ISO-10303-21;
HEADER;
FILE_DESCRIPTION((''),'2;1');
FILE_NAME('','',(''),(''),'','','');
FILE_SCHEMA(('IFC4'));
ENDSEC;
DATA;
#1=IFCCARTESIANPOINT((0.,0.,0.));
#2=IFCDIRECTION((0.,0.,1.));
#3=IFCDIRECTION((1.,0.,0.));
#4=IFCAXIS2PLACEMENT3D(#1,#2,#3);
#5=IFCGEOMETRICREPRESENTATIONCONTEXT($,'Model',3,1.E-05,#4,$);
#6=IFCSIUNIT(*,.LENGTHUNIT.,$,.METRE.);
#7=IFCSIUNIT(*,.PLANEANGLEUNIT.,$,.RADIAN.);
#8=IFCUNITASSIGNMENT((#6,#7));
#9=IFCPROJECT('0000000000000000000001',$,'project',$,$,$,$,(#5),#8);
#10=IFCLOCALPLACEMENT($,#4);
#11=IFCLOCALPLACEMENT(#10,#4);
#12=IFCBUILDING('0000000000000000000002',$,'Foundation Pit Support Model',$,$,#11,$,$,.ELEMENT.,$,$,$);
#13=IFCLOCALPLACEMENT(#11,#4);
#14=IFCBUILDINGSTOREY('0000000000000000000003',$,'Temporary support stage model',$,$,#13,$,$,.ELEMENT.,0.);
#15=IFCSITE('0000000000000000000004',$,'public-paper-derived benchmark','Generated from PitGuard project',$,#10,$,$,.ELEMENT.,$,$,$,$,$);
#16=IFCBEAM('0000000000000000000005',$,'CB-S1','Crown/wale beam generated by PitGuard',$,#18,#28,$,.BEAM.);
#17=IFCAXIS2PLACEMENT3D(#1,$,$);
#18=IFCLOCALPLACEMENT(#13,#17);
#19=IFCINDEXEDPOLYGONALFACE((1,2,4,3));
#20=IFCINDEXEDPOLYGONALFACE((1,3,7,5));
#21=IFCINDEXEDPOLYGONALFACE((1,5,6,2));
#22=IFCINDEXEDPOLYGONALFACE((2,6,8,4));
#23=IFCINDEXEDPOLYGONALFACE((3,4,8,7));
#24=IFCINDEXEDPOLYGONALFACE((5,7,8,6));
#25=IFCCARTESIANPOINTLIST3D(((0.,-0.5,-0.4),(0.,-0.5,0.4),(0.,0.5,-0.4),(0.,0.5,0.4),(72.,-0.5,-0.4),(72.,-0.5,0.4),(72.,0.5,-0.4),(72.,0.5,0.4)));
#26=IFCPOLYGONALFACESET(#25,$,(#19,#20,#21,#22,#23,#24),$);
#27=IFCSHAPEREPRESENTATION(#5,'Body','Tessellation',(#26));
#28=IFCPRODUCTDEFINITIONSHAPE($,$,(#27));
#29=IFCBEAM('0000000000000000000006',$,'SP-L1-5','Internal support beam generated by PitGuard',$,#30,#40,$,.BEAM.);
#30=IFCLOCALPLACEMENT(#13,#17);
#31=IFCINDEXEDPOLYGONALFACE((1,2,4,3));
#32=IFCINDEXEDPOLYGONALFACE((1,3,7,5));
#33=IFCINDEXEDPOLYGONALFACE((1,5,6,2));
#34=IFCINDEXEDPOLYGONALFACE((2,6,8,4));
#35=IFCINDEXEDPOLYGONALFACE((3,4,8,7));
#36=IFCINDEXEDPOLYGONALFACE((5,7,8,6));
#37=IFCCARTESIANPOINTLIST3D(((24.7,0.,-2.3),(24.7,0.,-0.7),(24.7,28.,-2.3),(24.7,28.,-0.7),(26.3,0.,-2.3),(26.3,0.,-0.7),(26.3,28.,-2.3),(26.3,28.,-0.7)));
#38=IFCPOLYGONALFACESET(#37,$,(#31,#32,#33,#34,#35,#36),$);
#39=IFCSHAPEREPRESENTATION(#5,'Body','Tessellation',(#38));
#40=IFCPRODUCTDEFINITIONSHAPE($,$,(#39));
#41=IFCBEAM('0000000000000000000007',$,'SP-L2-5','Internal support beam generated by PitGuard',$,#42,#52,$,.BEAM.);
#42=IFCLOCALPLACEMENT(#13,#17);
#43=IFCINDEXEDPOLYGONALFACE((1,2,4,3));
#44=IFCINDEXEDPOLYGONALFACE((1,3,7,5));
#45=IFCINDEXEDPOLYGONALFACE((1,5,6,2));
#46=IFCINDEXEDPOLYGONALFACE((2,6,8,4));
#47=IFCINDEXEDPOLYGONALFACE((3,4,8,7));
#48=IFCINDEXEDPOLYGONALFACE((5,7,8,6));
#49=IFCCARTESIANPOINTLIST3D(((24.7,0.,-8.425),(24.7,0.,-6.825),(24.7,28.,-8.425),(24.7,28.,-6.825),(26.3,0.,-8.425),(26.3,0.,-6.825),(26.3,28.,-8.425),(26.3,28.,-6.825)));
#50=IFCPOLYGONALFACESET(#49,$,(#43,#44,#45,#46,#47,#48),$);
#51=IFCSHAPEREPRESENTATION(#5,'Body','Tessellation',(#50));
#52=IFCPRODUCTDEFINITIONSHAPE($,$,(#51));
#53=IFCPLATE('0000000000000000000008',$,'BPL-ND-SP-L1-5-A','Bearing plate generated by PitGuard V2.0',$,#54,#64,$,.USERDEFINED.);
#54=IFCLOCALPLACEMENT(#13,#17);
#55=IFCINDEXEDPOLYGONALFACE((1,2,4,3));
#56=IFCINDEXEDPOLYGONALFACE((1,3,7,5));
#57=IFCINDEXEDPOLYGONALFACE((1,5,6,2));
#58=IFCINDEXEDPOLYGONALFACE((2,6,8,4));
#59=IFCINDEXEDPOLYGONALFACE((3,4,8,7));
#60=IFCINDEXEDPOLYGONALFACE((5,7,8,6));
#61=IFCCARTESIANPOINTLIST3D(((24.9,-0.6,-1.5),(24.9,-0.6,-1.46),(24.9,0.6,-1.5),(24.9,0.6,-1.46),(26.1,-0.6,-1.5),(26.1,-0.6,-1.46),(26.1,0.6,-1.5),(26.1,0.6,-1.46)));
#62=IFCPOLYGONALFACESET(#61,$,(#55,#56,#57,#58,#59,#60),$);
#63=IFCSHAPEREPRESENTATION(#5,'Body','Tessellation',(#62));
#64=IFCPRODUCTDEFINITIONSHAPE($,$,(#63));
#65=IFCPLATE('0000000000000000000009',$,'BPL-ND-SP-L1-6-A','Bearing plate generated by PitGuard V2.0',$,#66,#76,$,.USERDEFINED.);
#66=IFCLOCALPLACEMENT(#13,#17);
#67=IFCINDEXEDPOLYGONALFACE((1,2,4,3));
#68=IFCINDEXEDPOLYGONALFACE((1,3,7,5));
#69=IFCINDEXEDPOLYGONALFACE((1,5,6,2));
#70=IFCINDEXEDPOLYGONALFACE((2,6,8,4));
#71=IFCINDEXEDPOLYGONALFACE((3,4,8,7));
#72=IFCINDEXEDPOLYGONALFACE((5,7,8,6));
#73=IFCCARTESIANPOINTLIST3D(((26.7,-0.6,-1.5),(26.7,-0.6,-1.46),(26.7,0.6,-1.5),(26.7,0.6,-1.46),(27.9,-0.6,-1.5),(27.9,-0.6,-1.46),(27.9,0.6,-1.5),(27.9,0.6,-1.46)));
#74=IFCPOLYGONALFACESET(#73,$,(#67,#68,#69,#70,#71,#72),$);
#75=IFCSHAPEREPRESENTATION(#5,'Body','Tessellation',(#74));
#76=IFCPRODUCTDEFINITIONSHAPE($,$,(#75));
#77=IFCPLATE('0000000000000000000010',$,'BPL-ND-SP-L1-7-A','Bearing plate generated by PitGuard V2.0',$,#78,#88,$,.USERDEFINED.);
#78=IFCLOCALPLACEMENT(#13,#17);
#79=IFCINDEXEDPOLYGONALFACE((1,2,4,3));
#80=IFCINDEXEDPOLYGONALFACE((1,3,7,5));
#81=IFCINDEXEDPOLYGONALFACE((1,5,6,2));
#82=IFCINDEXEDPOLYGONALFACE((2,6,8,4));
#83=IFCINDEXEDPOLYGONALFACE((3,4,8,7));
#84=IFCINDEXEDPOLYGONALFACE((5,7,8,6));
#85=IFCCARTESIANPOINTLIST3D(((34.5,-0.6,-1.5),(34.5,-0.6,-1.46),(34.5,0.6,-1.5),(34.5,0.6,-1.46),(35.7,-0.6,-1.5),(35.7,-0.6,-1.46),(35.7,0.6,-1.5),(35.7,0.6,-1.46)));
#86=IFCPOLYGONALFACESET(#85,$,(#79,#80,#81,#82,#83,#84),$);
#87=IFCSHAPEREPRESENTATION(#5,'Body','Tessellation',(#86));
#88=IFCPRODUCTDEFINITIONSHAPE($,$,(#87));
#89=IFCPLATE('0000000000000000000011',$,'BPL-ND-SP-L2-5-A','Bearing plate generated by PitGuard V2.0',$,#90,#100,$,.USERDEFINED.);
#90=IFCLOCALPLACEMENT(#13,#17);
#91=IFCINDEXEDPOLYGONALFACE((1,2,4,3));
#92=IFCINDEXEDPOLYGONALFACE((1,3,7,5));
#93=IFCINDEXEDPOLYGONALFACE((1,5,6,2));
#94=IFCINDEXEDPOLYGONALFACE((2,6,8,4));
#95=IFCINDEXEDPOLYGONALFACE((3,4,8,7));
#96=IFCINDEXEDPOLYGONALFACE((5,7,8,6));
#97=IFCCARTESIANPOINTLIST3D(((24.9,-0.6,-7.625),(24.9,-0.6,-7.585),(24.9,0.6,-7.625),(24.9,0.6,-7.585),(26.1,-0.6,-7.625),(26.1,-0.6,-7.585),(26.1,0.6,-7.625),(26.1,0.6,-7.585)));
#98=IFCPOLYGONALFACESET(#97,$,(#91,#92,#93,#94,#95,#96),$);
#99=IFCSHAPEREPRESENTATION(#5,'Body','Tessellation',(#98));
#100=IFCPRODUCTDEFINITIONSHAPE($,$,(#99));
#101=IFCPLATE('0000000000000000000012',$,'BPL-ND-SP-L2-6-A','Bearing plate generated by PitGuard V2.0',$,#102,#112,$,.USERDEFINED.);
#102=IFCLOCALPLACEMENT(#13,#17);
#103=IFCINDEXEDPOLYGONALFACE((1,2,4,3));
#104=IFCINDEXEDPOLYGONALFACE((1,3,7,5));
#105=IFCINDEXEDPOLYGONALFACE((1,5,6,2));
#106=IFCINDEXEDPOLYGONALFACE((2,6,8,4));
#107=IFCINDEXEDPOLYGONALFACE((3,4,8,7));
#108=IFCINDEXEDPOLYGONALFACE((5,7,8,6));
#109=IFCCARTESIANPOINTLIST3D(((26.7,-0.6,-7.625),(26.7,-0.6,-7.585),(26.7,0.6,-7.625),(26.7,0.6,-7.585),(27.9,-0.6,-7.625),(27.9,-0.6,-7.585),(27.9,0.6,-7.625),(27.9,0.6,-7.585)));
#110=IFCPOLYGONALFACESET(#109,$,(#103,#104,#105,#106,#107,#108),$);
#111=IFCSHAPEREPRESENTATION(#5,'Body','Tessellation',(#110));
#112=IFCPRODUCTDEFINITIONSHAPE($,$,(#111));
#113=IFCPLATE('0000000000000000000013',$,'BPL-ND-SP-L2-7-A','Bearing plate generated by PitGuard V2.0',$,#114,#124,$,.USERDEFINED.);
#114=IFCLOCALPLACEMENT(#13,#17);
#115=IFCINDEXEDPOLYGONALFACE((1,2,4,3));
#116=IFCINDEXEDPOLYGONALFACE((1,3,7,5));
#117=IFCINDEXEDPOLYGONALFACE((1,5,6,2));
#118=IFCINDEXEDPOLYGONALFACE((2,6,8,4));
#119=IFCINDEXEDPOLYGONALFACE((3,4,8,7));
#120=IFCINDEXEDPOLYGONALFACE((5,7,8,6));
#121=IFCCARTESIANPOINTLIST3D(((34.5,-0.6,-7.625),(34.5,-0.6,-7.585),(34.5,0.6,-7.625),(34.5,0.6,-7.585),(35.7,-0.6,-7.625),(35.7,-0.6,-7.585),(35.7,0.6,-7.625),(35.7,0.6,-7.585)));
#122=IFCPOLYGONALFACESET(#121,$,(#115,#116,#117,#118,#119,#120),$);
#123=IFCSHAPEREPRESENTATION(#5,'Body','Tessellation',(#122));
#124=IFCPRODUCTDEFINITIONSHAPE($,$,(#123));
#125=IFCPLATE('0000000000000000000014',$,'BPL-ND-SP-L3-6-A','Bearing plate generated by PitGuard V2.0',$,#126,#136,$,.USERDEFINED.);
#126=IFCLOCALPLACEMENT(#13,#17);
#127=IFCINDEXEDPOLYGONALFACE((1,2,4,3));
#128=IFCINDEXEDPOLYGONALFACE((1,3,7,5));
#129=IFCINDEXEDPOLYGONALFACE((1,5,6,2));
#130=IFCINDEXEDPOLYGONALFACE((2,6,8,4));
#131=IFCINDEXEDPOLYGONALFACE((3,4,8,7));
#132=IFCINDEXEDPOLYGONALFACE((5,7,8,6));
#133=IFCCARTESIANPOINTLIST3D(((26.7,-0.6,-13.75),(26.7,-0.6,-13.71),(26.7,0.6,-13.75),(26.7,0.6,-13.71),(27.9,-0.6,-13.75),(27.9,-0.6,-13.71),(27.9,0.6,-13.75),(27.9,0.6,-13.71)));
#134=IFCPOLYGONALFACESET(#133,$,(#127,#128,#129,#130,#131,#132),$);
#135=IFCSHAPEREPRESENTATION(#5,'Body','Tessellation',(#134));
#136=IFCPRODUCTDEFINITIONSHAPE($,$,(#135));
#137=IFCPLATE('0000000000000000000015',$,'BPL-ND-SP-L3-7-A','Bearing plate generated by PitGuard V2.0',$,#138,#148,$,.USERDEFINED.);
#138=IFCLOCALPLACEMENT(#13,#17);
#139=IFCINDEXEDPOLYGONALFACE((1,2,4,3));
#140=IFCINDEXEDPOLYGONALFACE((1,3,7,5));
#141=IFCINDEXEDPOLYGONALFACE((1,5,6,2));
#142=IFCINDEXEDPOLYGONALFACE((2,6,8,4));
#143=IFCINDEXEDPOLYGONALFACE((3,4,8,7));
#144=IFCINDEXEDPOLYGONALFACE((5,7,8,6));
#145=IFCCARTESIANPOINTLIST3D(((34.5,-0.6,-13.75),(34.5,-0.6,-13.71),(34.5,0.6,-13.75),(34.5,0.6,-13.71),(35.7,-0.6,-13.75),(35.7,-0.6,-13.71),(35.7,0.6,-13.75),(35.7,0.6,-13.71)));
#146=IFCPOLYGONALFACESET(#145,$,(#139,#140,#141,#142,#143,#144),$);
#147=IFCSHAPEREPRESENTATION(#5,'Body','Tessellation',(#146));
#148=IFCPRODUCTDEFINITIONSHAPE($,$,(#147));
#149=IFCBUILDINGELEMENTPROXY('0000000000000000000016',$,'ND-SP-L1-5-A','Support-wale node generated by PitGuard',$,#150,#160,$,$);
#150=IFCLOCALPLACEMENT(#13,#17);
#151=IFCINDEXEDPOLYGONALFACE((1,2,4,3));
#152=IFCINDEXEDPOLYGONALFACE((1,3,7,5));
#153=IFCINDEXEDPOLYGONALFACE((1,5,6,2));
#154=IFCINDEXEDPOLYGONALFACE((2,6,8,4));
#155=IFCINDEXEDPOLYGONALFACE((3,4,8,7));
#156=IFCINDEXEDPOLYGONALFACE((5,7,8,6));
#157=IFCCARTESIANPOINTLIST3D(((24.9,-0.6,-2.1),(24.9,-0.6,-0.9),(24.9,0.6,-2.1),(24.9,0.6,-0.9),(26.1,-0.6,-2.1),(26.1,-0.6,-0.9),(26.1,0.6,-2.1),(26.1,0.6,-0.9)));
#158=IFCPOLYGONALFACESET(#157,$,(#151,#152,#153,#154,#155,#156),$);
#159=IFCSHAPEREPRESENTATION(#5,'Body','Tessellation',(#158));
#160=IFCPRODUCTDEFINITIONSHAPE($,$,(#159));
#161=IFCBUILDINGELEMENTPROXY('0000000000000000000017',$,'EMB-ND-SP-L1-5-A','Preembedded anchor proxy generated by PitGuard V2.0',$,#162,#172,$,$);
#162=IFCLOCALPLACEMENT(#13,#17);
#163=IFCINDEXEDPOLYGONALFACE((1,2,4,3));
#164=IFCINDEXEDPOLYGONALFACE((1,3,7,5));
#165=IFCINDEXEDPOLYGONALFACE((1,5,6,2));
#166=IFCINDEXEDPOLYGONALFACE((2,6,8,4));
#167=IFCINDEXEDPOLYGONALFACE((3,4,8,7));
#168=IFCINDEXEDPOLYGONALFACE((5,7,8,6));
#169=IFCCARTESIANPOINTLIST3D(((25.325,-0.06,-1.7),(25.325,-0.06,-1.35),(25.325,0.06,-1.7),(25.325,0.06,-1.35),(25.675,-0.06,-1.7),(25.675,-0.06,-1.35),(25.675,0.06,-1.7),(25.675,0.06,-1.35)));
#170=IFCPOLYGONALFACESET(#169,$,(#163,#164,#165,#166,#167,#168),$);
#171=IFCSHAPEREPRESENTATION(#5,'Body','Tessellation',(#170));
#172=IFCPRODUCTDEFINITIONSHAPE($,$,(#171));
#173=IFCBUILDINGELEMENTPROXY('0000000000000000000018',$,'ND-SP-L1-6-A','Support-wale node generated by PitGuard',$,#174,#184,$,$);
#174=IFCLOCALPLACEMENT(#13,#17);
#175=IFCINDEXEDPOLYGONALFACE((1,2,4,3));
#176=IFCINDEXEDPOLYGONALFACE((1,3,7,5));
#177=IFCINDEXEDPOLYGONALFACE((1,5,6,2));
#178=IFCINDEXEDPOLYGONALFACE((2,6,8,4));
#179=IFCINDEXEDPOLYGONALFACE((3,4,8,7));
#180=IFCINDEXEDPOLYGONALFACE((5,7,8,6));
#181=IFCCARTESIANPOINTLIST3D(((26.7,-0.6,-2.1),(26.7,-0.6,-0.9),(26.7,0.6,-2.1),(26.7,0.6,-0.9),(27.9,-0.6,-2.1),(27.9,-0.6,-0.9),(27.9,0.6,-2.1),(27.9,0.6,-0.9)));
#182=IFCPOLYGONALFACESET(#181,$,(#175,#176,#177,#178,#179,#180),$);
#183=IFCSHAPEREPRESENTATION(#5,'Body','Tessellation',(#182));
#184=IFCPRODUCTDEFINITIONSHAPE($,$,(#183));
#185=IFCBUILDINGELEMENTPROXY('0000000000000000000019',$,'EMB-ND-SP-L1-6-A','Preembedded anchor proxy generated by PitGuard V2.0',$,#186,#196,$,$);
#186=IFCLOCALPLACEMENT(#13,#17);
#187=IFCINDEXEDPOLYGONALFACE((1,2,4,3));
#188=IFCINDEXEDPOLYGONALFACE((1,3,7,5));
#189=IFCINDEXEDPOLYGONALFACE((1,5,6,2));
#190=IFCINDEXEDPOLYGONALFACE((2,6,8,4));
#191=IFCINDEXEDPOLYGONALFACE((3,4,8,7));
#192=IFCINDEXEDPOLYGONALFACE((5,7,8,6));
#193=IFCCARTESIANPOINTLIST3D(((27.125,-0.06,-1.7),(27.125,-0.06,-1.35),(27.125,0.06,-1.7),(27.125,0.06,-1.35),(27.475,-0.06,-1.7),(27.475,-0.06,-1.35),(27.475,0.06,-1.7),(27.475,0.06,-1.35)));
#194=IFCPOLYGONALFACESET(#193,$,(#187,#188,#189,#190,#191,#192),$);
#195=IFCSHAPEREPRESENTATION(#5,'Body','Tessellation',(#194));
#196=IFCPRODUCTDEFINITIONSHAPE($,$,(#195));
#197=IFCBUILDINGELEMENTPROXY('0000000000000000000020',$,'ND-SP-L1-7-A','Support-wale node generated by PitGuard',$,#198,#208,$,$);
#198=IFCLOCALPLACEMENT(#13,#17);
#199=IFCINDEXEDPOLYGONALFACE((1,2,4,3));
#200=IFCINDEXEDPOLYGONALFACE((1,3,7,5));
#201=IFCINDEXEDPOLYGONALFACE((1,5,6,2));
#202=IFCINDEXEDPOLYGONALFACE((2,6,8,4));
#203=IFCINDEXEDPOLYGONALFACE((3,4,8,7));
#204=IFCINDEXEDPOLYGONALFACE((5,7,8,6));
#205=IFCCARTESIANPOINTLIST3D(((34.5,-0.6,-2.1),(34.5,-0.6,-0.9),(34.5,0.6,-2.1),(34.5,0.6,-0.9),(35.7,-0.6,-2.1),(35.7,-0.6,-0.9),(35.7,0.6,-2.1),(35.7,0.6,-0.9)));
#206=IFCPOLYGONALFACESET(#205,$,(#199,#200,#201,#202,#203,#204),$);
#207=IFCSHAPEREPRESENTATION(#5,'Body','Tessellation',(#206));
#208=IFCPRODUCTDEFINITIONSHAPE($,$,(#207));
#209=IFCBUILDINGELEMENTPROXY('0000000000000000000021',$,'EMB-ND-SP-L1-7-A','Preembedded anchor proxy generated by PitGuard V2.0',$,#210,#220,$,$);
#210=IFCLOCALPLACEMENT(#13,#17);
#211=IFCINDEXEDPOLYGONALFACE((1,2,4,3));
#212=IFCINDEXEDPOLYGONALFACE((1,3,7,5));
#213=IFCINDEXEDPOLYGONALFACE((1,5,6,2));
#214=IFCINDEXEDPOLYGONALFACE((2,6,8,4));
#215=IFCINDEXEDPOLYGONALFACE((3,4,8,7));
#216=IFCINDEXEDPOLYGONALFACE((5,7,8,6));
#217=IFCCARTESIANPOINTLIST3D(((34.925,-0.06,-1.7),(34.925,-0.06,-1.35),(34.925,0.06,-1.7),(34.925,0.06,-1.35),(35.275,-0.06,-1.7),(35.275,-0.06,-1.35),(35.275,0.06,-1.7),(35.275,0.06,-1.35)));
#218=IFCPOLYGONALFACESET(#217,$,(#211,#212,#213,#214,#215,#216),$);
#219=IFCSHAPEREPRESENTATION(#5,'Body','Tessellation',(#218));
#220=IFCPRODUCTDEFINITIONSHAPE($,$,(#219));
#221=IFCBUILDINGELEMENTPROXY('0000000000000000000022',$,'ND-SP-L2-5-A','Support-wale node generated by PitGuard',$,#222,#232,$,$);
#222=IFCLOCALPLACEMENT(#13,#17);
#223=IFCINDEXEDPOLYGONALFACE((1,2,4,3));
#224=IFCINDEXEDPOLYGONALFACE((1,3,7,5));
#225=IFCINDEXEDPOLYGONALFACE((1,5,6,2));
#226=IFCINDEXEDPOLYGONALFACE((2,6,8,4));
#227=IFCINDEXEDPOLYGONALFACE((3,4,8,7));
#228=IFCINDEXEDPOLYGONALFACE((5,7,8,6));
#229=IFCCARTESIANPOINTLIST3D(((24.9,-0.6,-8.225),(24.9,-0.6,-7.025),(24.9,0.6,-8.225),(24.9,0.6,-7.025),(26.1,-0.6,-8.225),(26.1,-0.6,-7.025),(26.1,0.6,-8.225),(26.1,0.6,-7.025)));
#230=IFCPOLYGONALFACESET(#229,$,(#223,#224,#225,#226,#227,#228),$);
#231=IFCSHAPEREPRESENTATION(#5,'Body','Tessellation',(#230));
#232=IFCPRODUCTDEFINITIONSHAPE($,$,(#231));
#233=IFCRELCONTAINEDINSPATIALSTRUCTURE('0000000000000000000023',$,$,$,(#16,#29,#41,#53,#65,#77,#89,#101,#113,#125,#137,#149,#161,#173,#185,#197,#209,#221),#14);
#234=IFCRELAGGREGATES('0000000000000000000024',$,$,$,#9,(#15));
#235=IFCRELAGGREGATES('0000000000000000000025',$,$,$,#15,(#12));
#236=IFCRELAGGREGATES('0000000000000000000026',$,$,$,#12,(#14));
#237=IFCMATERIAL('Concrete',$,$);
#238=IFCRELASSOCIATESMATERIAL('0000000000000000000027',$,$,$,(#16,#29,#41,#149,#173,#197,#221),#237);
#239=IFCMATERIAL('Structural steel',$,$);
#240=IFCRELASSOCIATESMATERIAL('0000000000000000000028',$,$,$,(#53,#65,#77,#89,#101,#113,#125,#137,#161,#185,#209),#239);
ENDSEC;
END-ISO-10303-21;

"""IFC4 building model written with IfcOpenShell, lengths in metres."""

from ifc_helpers import new_model, si_unit, frame, origin_with_axes, origin_2d, place, context, project, spatial, rectangle, extrude, material, element, save


model = new_model("IFC4")

# Units and contexts
model_context = context("Model", 3, precision=1e-05, world=origin_with_axes())
ifc_project = project(units=[si_unit("LENGTHUNIT", "METRE"), si_unit("PLANEANGLEUNIT", "RADIAN")], contexts=[model_context])

# Site, building, storey
site_placement = place(None, origin_with_axes())
site = spatial("IfcSite", under=ifc_project, at=site_placement, Name="public-paper-derived benchmark", Description="Generated from PitGuard project", CompositionType="ELEMENT")
building_placement = place(site_placement, origin_with_axes())
building = spatial("IfcBuilding", under=site, at=building_placement, Name="Foundation Pit Support Model", CompositionType="ELEMENT")
storey_placement = place(building_placement, origin_with_axes())
storey = spatial("IfcBuildingStorey", under=building, at=storey_placement, Name="Temporary support stage model", CompositionType="ELEMENT", Elevation=0.0)

# Beams
ifc_material_1 = material(Name="Concrete")
beam_placement = place(storey_placement, frame((36.0, 0.0, -0.4), z_axis=(0.0, 0.0, 1.0), x_axis=(1.0, 0.0, 0.0)))
element("IfcBeam", 1, at=beam_placement, inside=storey, material=ifc_material_1, Name="CB-S1", Description="Crown/wale beam generated by PitGuard", PredefinedType="BEAM", context=model_context, shape_type="SweptSolid", body=[
    extrude(rectangle(XDim=72.0, YDim=1.0, at=origin_2d()), origin_with_axes(), (0.0, 0.0, 1.0), 0.8),
])
for number, where, z_axis, x_axis, name in (
    (2, (25.5, 14.0, -2.3), (0.0, 0.0, 1.0), (0.0, 1.0, 0.0), "SP-L1-5"),
    (3, (25.5, 14.0, -8.425), (0.0, 0.0, 1.0), (0.0, 1.0, 0.0), "SP-L2-5"),
):
    element("IfcBeam", number, at=place(storey_placement, frame(where, z_axis=z_axis, x_axis=x_axis)), inside=storey, material=ifc_material_1, Name=name, Description="Internal support beam generated by PitGuard", PredefinedType="BEAM", context=model_context, shape_type="SweptSolid", body=[
        extrude(rectangle(XDim=28.0, YDim=1.6, at=origin_2d()), origin_with_axes(), (0.0, 0.0, 1.0), 1.6),
    ])

# Plates
ifc_material_2 = material(Name="Structural steel")
for number, where, z_axis, x_axis, name in (
    (4, (25.5, 0.0, -1.5), (0.0, 0.0, 1.0), (1.0, 0.0, 0.0), "BPL-ND-SP-L1-5-A"),
    (5, (27.3, 0.0, -1.5), (0.0, 0.0, 1.0), (1.0, 0.0, 0.0), "BPL-ND-SP-L1-6-A"),
    (6, (35.1, 0.0, -1.5), (0.0, 0.0, 1.0), (1.0, 0.0, 0.0), "BPL-ND-SP-L1-7-A"),
    (7, (25.5, 0.0, -7.625), (0.0, 0.0, 1.0), (1.0, 0.0, 0.0), "BPL-ND-SP-L2-5-A"),
    (8, (27.3, 0.0, -7.625), (0.0, 0.0, 1.0), (1.0, 0.0, 0.0), "BPL-ND-SP-L2-6-A"),
    (9, (35.1, 0.0, -7.625), (0.0, 0.0, 1.0), (1.0, 0.0, 0.0), "BPL-ND-SP-L2-7-A"),
    (10, (27.3, 0.0, -13.75), (0.0, 0.0, 1.0), (1.0, 0.0, 0.0), "BPL-ND-SP-L3-6-A"),
    (11, (35.1, 0.0, -13.75), (0.0, 0.0, 1.0), (1.0, 0.0, 0.0), "BPL-ND-SP-L3-7-A"),
):
    element("IfcPlate", number, at=place(storey_placement, frame(where, z_axis=z_axis, x_axis=x_axis)), inside=storey, material=ifc_material_2, Name=name, Description="Bearing plate generated by PitGuard V2.0", PredefinedType="USERDEFINED", context=model_context, shape_type="SweptSolid", body=[
        extrude(rectangle(XDim=1.2, YDim=1.2, at=origin_2d()), origin_with_axes(), (0.0, 0.0, 1.0), 0.04),
    ])

# Building element proxies
proxy_1_placement = place(storey_placement, frame((25.5, 0.0, -2.1), z_axis=(0.0, 0.0, 1.0), x_axis=(1.0, 0.0, 0.0)))
element("IfcBuildingElementProxy", 12, at=proxy_1_placement, inside=storey, material=ifc_material_1, Name="ND-SP-L1-5-A", Description="Support-wale node generated by PitGuard", context=model_context, shape_type="SweptSolid", body=[
    extrude(rectangle(XDim=1.2, YDim=1.2, at=origin_2d()), origin_with_axes(), (0.0, 0.0, 1.0), 1.2),
])
proxy_2_placement = place(storey_placement, frame((25.5, 0.0, -1.7), z_axis=(0.0, 0.0, 1.0), x_axis=(1.0, 0.0, 0.0)))
element("IfcBuildingElementProxy", 13, at=proxy_2_placement, inside=storey, material=ifc_material_2, Name="EMB-ND-SP-L1-5-A", Description="Preembedded anchor proxy generated by PitGuard V2.0", context=model_context, shape_type="SweptSolid", body=[
    extrude(rectangle(XDim=0.35, YDim=0.12, at=origin_2d()), origin_with_axes(), (0.0, 0.0, 1.0), 0.35),
])
proxy_3_placement = place(storey_placement, frame((27.3, 0.0, -2.1), z_axis=(0.0, 0.0, 1.0), x_axis=(1.0, 0.0, 0.0)))
element("IfcBuildingElementProxy", 14, at=proxy_3_placement, inside=storey, material=ifc_material_1, Name="ND-SP-L1-6-A", Description="Support-wale node generated by PitGuard", context=model_context, shape_type="SweptSolid", body=[
    extrude(rectangle(XDim=1.2, YDim=1.2, at=origin_2d()), origin_with_axes(), (0.0, 0.0, 1.0), 1.2),
])
proxy_4_placement = place(storey_placement, frame((27.3, 0.0, -1.7), z_axis=(0.0, 0.0, 1.0), x_axis=(1.0, 0.0, 0.0)))
element("IfcBuildingElementProxy", 15, at=proxy_4_placement, inside=storey, material=ifc_material_2, Name="EMB-ND-SP-L1-6-A", Description="Preembedded anchor proxy generated by PitGuard V2.0", context=model_context, shape_type="SweptSolid", body=[
    extrude(rectangle(XDim=0.35, YDim=0.12, at=origin_2d()), origin_with_axes(), (0.0, 0.0, 1.0), 0.35),
])
proxy_5_placement = place(storey_placement, frame((35.1, 0.0, -2.1), z_axis=(0.0, 0.0, 1.0), x_axis=(1.0, 0.0, 0.0)))
element("IfcBuildingElementProxy", 16, at=proxy_5_placement, inside=storey, material=ifc_material_1, Name="ND-SP-L1-7-A", Description="Support-wale node generated by PitGuard", context=model_context, shape_type="SweptSolid", body=[
    extrude(rectangle(XDim=1.2, YDim=1.2, at=origin_2d()), origin_with_axes(), (0.0, 0.0, 1.0), 1.2),
])
proxy_6_placement = place(storey_placement, frame((35.1, 0.0, -1.7), z_axis=(0.0, 0.0, 1.0), x_axis=(1.0, 0.0, 0.0)))
element("IfcBuildingElementProxy", 17, at=proxy_6_placement, inside=storey, material=ifc_material_2, Name="EMB-ND-SP-L1-7-A", Description="Preembedded anchor proxy generated by PitGuard V2.0", context=model_context, shape_type="SweptSolid", body=[
    extrude(rectangle(XDim=0.35, YDim=0.12, at=origin_2d()), origin_with_axes(), (0.0, 0.0, 1.0), 0.35),
])
proxy_7_placement = place(storey_placement, frame((25.5, 0.0, -8.225), z_axis=(0.0, 0.0, 1.0), x_axis=(1.0, 0.0, 0.0)))
element("IfcBuildingElementProxy", 18, at=proxy_7_placement, inside=storey, material=ifc_material_1, Name="ND-SP-L2-5-A", Description="Support-wale node generated by PitGuard", context=model_context, shape_type="SweptSolid", body=[
    extrude(rectangle(XDim=1.2, YDim=1.2, at=origin_2d()), origin_with_axes(), (0.0, 0.0, 1.0), 1.2),
])

save(model, "model.ifc")
